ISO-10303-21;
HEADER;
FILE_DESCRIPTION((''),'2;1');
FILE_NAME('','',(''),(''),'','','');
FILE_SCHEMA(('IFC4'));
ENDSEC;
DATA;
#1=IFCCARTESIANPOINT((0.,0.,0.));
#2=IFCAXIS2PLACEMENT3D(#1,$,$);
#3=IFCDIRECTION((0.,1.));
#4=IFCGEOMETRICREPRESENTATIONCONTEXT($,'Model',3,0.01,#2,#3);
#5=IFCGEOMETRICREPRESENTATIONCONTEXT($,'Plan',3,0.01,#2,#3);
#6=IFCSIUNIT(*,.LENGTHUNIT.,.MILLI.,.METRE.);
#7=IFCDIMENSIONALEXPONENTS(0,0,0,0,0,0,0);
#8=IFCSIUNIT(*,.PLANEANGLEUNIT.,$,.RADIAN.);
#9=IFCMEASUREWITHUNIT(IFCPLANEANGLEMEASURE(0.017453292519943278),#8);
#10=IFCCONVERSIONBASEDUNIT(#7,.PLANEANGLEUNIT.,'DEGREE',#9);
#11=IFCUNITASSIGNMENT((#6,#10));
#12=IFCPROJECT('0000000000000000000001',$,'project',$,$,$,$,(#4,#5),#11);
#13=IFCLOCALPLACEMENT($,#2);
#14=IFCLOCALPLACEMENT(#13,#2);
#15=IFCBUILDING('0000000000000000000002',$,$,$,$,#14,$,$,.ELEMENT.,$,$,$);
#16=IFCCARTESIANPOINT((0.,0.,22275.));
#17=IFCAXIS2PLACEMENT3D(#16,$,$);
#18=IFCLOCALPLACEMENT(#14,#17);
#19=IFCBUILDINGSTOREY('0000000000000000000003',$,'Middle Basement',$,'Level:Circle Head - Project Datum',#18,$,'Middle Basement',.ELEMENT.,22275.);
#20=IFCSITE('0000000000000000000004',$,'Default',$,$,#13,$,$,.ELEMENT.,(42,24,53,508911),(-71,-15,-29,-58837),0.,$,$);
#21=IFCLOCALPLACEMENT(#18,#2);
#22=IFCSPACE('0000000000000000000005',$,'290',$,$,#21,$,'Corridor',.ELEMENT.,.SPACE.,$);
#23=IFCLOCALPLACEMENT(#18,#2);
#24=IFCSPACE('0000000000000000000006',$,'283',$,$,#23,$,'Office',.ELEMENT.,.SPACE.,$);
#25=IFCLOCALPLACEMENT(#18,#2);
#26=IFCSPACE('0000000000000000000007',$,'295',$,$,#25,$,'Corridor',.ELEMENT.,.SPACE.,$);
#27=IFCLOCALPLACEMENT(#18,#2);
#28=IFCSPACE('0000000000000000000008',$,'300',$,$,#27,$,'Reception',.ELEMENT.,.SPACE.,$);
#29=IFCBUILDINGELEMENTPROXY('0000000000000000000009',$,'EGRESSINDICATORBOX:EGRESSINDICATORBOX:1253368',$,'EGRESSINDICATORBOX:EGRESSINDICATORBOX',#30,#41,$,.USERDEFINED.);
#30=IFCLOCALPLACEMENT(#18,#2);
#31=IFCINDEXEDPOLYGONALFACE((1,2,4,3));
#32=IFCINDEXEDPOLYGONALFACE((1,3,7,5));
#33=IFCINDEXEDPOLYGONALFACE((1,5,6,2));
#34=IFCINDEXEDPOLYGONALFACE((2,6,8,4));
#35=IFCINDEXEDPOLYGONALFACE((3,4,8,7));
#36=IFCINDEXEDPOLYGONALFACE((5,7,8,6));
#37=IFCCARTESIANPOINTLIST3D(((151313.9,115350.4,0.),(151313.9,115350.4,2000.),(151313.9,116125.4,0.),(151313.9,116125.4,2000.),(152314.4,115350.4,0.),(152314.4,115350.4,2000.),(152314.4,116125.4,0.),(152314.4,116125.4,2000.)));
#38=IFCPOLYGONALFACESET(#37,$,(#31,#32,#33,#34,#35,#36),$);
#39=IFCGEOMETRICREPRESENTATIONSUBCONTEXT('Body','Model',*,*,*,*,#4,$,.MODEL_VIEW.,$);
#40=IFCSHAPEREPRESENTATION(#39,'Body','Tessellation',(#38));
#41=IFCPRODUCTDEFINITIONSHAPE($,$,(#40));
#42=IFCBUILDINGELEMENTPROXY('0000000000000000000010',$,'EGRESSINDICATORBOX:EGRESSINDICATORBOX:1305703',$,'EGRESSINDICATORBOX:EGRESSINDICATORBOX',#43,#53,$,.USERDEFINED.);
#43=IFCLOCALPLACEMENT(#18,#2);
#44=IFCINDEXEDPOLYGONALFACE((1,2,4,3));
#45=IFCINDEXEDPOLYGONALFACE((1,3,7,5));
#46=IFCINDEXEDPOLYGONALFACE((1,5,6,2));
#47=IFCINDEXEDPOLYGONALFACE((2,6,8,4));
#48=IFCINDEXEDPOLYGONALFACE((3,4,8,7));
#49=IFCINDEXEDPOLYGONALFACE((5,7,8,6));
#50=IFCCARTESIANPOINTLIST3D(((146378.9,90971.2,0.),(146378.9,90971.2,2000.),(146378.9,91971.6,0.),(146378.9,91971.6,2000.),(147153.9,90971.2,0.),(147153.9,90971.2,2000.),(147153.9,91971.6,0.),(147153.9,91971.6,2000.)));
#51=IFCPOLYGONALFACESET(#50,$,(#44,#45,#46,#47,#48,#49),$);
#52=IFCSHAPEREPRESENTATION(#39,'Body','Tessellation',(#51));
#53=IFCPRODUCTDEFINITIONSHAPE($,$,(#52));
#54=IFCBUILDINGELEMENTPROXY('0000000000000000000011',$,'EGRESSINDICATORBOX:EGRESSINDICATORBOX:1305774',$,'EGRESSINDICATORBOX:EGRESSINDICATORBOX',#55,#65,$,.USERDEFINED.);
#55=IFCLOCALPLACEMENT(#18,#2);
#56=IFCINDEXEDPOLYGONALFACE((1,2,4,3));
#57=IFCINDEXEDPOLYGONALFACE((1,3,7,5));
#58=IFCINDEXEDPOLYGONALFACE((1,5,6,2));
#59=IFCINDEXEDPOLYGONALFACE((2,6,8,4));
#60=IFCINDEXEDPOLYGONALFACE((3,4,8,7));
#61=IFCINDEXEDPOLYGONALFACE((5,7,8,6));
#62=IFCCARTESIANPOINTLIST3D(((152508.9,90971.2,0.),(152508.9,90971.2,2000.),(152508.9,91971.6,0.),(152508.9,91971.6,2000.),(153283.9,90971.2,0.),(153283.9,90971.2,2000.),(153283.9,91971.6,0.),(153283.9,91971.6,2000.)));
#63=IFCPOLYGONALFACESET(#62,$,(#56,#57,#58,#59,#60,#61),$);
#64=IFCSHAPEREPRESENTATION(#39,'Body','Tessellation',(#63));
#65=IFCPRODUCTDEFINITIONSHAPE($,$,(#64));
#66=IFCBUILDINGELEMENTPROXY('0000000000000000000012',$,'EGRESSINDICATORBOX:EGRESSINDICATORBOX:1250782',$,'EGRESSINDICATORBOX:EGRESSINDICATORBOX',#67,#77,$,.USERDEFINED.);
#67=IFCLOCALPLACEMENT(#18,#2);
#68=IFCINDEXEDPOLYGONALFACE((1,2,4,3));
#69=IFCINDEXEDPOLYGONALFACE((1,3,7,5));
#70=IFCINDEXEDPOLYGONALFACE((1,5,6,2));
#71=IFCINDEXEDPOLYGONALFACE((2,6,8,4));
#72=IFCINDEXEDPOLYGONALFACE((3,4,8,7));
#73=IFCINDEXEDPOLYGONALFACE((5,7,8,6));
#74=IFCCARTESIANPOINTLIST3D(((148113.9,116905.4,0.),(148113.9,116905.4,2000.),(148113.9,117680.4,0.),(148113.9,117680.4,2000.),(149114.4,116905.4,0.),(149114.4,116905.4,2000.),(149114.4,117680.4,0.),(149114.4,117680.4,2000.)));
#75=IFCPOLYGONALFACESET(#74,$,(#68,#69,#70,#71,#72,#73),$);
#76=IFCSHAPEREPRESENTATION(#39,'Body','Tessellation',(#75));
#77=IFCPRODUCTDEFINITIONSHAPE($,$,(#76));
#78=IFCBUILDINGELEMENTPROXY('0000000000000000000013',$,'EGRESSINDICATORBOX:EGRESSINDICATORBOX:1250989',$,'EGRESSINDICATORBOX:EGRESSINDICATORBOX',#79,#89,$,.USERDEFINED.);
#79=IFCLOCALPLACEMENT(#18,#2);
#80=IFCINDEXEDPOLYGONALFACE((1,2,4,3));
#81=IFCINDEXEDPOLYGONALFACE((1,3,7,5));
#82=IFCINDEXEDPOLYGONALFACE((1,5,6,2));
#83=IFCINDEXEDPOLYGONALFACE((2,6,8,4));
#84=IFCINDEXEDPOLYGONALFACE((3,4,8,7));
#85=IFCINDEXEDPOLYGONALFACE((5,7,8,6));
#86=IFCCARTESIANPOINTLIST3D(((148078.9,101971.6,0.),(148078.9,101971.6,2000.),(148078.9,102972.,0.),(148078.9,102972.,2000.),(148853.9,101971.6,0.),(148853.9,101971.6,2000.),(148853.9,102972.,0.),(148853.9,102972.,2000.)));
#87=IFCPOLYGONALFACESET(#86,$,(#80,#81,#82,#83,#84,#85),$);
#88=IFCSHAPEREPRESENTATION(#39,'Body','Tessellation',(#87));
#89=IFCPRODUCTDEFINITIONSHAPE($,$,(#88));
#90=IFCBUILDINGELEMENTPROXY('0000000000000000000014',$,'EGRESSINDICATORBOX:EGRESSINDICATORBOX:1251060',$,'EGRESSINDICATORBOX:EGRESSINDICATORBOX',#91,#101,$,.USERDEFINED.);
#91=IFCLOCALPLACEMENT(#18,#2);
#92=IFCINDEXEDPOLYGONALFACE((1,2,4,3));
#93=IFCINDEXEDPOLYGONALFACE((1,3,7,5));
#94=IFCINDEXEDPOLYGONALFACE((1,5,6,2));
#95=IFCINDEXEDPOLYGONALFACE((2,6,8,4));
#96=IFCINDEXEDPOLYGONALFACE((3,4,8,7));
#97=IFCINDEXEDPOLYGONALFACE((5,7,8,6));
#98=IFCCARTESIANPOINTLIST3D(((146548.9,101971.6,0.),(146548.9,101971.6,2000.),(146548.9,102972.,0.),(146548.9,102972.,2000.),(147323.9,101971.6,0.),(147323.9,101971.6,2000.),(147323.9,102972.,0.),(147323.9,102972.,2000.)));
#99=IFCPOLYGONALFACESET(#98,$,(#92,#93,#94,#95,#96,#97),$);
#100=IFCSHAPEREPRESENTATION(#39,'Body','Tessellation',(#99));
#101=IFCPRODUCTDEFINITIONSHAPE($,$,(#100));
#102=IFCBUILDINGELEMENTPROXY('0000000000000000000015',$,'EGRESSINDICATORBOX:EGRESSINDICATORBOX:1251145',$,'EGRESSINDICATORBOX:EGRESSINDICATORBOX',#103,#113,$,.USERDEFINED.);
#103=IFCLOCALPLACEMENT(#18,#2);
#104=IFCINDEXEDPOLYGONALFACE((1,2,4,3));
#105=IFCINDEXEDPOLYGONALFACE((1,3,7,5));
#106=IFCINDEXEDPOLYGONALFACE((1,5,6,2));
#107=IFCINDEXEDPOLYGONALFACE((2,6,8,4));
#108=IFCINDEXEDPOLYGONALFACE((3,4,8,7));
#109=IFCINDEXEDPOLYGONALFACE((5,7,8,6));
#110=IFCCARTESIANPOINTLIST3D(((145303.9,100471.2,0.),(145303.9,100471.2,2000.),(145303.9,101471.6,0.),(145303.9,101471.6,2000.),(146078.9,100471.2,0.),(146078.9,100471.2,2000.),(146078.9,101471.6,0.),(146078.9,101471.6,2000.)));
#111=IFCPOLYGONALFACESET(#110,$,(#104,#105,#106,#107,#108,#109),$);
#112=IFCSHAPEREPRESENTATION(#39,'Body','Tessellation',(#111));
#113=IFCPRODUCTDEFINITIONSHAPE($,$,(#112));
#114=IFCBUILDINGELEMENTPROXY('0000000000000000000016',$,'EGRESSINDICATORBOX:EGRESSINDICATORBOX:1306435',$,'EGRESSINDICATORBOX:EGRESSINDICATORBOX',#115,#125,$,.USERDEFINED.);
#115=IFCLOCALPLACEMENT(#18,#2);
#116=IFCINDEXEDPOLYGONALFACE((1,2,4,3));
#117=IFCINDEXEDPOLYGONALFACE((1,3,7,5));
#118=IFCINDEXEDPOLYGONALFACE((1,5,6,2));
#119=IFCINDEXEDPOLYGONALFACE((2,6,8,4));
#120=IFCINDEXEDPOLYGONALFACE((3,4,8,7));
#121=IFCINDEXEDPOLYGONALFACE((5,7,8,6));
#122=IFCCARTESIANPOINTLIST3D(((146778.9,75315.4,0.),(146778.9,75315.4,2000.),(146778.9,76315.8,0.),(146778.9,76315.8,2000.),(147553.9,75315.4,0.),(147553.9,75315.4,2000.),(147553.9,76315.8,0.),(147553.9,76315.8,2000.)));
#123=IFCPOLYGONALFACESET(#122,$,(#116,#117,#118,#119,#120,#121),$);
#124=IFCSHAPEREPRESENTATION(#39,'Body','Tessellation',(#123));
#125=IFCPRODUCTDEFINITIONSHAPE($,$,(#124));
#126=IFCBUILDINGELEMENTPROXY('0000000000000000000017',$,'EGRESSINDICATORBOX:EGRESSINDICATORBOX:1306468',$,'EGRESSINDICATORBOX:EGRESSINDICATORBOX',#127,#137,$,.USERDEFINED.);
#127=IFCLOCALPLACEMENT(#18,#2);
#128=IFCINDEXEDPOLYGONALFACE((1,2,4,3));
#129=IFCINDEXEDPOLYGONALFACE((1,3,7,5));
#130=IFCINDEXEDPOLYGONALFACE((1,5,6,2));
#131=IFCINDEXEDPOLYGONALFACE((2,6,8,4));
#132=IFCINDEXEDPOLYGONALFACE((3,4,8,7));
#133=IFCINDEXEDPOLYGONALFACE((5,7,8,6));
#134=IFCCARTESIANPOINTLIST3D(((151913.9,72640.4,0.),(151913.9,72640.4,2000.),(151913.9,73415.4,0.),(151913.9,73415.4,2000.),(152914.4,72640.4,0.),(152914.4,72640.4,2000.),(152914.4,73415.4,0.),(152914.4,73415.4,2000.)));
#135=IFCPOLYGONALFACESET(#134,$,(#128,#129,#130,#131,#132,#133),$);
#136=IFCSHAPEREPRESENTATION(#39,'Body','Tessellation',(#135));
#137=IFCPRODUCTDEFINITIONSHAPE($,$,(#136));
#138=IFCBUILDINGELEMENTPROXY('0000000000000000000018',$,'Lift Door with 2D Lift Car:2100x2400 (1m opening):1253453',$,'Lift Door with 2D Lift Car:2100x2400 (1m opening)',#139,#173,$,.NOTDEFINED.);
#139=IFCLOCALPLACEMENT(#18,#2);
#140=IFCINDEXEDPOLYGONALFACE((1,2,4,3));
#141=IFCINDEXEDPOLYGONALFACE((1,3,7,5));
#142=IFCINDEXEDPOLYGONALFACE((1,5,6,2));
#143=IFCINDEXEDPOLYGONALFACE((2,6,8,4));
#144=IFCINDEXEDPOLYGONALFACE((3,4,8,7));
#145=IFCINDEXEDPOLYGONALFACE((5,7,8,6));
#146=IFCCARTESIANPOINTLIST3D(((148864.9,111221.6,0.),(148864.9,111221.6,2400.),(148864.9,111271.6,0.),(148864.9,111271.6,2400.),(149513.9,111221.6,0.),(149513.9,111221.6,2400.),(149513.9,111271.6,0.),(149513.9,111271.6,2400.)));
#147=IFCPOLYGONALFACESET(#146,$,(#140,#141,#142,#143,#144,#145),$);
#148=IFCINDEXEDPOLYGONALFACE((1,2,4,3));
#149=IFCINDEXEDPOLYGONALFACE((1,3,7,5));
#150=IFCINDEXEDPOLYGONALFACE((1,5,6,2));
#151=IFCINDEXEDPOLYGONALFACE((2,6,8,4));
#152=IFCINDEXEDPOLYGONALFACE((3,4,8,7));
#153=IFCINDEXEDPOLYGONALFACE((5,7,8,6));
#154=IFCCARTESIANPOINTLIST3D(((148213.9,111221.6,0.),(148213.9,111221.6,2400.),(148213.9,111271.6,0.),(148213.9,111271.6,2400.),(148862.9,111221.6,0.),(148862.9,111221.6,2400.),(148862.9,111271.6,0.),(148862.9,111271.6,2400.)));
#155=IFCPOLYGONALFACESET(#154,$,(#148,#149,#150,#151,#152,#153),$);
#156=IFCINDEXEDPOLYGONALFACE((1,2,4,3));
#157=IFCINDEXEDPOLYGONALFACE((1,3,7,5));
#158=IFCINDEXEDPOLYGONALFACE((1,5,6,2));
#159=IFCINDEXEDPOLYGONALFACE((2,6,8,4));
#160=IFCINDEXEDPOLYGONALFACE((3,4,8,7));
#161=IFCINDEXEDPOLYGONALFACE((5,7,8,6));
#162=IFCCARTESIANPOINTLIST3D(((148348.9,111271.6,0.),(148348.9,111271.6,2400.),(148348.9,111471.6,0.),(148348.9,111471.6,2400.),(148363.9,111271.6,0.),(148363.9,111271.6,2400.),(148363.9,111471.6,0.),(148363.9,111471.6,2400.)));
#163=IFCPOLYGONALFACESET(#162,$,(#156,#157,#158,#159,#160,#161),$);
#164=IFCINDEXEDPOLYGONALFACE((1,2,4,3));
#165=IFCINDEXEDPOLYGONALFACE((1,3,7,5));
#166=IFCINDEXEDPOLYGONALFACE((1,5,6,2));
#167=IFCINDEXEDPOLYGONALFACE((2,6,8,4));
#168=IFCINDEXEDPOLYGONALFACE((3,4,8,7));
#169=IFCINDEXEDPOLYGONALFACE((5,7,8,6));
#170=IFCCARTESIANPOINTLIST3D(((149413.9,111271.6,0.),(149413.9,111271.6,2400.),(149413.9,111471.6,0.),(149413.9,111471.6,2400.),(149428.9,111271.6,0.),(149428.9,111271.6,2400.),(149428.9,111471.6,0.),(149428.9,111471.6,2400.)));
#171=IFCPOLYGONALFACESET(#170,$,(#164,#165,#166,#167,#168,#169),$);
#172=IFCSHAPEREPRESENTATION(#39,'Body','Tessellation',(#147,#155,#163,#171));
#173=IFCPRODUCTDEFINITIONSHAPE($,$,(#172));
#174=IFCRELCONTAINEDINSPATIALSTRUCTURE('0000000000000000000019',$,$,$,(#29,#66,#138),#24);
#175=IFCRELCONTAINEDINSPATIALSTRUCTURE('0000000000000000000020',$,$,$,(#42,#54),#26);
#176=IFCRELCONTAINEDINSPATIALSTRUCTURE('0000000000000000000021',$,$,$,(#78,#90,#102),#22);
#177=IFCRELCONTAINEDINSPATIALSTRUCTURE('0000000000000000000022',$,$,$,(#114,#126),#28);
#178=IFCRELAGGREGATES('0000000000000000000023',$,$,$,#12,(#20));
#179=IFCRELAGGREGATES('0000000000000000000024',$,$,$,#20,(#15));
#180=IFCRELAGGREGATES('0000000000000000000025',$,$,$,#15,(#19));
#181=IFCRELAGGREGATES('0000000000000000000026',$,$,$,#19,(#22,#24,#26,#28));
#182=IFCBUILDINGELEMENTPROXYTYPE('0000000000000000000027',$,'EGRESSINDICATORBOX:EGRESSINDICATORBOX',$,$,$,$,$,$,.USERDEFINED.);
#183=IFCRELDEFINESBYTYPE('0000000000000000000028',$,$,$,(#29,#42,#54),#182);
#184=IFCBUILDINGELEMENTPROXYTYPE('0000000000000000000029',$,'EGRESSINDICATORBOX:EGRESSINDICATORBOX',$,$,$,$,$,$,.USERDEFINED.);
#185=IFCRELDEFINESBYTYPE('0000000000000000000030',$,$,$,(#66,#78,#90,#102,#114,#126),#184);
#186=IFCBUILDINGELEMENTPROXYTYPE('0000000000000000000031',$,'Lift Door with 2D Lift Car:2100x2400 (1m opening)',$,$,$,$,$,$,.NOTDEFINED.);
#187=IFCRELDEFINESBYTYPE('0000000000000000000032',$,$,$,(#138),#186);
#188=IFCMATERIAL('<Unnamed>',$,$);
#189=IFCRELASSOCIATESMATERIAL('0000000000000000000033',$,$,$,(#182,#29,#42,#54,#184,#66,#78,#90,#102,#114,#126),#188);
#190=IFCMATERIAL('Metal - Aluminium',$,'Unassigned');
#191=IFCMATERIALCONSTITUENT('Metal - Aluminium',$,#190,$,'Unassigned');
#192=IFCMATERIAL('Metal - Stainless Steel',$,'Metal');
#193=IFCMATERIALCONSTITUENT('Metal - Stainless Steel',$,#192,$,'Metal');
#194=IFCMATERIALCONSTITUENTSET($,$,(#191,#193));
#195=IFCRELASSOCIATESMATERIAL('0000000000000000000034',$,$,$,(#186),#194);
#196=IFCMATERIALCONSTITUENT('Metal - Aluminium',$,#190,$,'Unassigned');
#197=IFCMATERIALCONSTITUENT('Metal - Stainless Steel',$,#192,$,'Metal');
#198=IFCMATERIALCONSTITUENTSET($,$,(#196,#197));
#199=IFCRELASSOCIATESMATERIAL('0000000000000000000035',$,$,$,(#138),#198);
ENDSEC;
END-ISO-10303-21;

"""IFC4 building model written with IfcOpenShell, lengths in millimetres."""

from ifc_helpers import new_model, entity, si_unit, converted_unit, direction, frame, origin, place, context, subcontext, project, spatial, indexed_curve, outline, extrude, source, transform, mapped, material, constituent, constituent_set, type_object, type_shapes, element, save


model = new_model("IFC4")

# Units and contexts
model_context = context("Model", 3, precision=0.01, world=origin(), true_north=direction((0.0, 1.0)))
plan_context = context("Plan", 3, precision=0.01, world=origin(), true_north=direction((0.0, 1.0)))
body_context = subcontext(model_context, "Body", "Model", "MODEL_VIEW")
ifc_project = project(units=[si_unit("LENGTHUNIT", "METRE", prefix="MILLI"), converted_unit("PLANEANGLEUNIT", "DEGREE", entity("IfcPlaneAngleMeasure", 0.017453292519943278), si_unit("PLANEANGLEUNIT", "RADIAN"), dimensions=[0, 0, 0, 0, 0, 0, 0])], contexts=[model_context, plan_context])

# Site, building, storey
site_placement = place(None, origin())
site = spatial("IfcSite", under=ifc_project, at=site_placement, Name="Default", CompositionType="ELEMENT", RefLatitude=(42, 24, 53, 508911), RefLongitude=(-71, -15, -29, -58837), RefElevation=0.0)
building_placement = place(site_placement, origin())
building = spatial("IfcBuilding", under=site, at=building_placement, CompositionType="ELEMENT")
storey_placement = place(building_placement, frame((0.0, 0.0, 22275.0)))
storey = spatial("IfcBuildingStorey", under=building, at=storey_placement, Name="Middle Basement", ObjectType="Level:Circle Head - Project Datum", LongName="Middle Basement", CompositionType="ELEMENT", Elevation=22275.0)

# Shared definitions
ifc_material_1 = material(Name="<Unnamed>")

# Shared definitions
building_element_proxy_type_1 = type_object("IfcBuildingElementProxyType", Name="EGRESSINDICATORBOX:EGRESSINDICATORBOX", PredefinedType="USERDEFINED", material=ifc_material_1)
shared_shape_1 = source(origin(), body_context, "Body", "SweptSolid", [
    extrude(outline(indexed_curve([(-387.5, -500.2), (387.5, -500.2), (387.5, 500.2), (-387.5, 500.2), (-387.5, -500.2)], self_intersect=False)), frame((0.0, 0.0, 0.0), z_axis=(0.0, 0.0, 1.0), x_axis=(-1.0, 0.0, 0.0)), (0.0, 0.0, 1.0), 2000.0),
])
type_shapes(building_element_proxy_type_1, [shared_shape_1])

# Shared definitions
space_1_placement = place(storey_placement, origin())
space_1 = spatial("IfcSpace", under=storey, at=space_1_placement, Name="290", LongName="Corridor", CompositionType="ELEMENT", PredefinedType="SPACE")

# Shared definitions
space_2_placement = place(storey_placement, origin())
space_2 = spatial("IfcSpace", under=storey, at=space_2_placement, Name="283", LongName="Office", CompositionType="ELEMENT", PredefinedType="SPACE")

# Building element proxy
proxy_1_placement = place(space_2_placement, frame((151814.2, 115737.9, 0.0), z_axis=(0.0, 0.0, 1.0), x_axis=(0.0, 1.0, 0.0)))
element("IfcBuildingElementProxy", 1, at=proxy_1_placement, inside=space_2, type_object=building_element_proxy_type_1, material=ifc_material_1, Name="EGRESSINDICATORBOX:EGRESSINDICATORBOX:1253368", ObjectType="EGRESSINDICATORBOX:EGRESSINDICATORBOX", PredefinedType="USERDEFINED", context=body_context, shape_type="MappedRepresentation", body=[
    mapped(shared_shape_1, transform((0.0, 0.0, 0.0), scale=1.0)),
])

# Shared definitions
space_3_placement = place(storey_placement, origin())
space_3 = spatial("IfcSpace", under=storey, at=space_3_placement, Name="295", LongName="Corridor", CompositionType="ELEMENT", PredefinedType="SPACE")

# Building element proxies
for number, where, name in (
    (2, (146766.4, 91471.4, 0.0), "EGRESSINDICATORBOX:EGRESSINDICATORBOX:1305703"),
    (3, (152896.4, 91471.4, 0.0), "EGRESSINDICATORBOX:EGRESSINDICATORBOX:1305774"),
):
    element("IfcBuildingElementProxy", number, at=place(space_3_placement, frame(where)), inside=space_3, type_object=building_element_proxy_type_1, material=ifc_material_1, Name=name, ObjectType="EGRESSINDICATORBOX:EGRESSINDICATORBOX", PredefinedType="USERDEFINED", context=body_context, shape_type="MappedRepresentation", body=[
        mapped(shared_shape_1, transform((0.0, 0.0, 0.0), scale=1.0)),
    ])
building_element_proxy_type_2 = type_object("IfcBuildingElementProxyType", Name="EGRESSINDICATORBOX:EGRESSINDICATORBOX", PredefinedType="USERDEFINED", material=ifc_material_1)
shared_shape_2 = source(origin(), body_context, "Body", "SweptSolid", [
    extrude(outline(indexed_curve([(-500.2, -387.5), (500.2, -387.5), (500.2, 387.5), (-500.2, 387.5), (-500.2, -387.5)], self_intersect=False)), frame((0.0, 0.0, 0.0), z_axis=(0.0, 0.0, 1.0), x_axis=(0.0, 1.0, 0.0)), (0.0, 0.0, 1.0), 2000.0),
])
type_shapes(building_element_proxy_type_2, [shared_shape_2])
proxy_2_placement = place(space_2_placement, frame((148614.2, 117292.9, 0.0), z_axis=(0.0, 0.0, 1.0), x_axis=(0.0, -1.0, 0.0)))
element("IfcBuildingElementProxy", 4, at=proxy_2_placement, inside=space_2, type_object=building_element_proxy_type_2, material=ifc_material_1, Name="EGRESSINDICATORBOX:EGRESSINDICATORBOX:1250782", ObjectType="EGRESSINDICATORBOX:EGRESSINDICATORBOX", PredefinedType="USERDEFINED", context=body_context, shape_type="MappedRepresentation", body=[
    mapped(shared_shape_2, transform((0.0, 0.0, 0.0), scale=1.0)),
])
for number, where, name in (
    (5, (148466.4, 102471.8, 0.0), "EGRESSINDICATORBOX:EGRESSINDICATORBOX:1250989"),
    (6, (146936.4, 102471.8, 0.0), "EGRESSINDICATORBOX:EGRESSINDICATORBOX:1251060"),
):
    element("IfcBuildingElementProxy", number, at=place(space_1_placement, frame(where)), inside=space_1, type_object=building_element_proxy_type_2, material=ifc_material_1, Name=name, ObjectType="EGRESSINDICATORBOX:EGRESSINDICATORBOX", PredefinedType="USERDEFINED", context=body_context, shape_type="MappedRepresentation", body=[
        mapped(shared_shape_2, transform((0.0, 0.0, 0.0), scale=1.0)),
    ])
proxy_3_placement = place(space_1_placement, frame((145691.4, 100971.4, 0.0), z_axis=(0.0, 0.0, 1.0), x_axis=(-1.0, 0.0, 0.0)))
element("IfcBuildingElementProxy", 7, at=proxy_3_placement, inside=space_1, type_object=building_element_proxy_type_2, material=ifc_material_1, Name="EGRESSINDICATORBOX:EGRESSINDICATORBOX:1251145", ObjectType="EGRESSINDICATORBOX:EGRESSINDICATORBOX", PredefinedType="USERDEFINED", context=body_context, shape_type="MappedRepresentation", body=[
    mapped(shared_shape_2, transform((0.0, 0.0, 0.0), scale=1.0)),
])

# Shared definitions
space_4_placement = place(storey_placement, origin())
space_4 = spatial("IfcSpace", under=storey, at=space_4_placement, Name="300", LongName="Reception", CompositionType="ELEMENT", PredefinedType="SPACE")

# Building element proxies
proxy_4_placement = place(space_4_placement, frame((147166.4, 75815.6, 0.0)))
element("IfcBuildingElementProxy", 8, at=proxy_4_placement, inside=space_4, type_object=building_element_proxy_type_2, material=ifc_material_1, Name="EGRESSINDICATORBOX:EGRESSINDICATORBOX:1306435", ObjectType="EGRESSINDICATORBOX:EGRESSINDICATORBOX", PredefinedType="USERDEFINED", context=body_context, shape_type="MappedRepresentation", body=[
    mapped(shared_shape_2, transform((0.0, 0.0, 0.0), scale=1.0)),
])
proxy_5_placement = place(space_4_placement, frame((152414.2, 73027.9, 0.0), z_axis=(0.0, 0.0, 1.0), x_axis=(0.0, -1.0, 0.0)))
element("IfcBuildingElementProxy", 9, at=proxy_5_placement, inside=space_4, type_object=building_element_proxy_type_2, material=ifc_material_1, Name="EGRESSINDICATORBOX:EGRESSINDICATORBOX:1306468", ObjectType="EGRESSINDICATORBOX:EGRESSINDICATORBOX", PredefinedType="USERDEFINED", context=body_context, shape_type="MappedRepresentation", body=[
    mapped(shared_shape_2, transform((0.0, 0.0, 0.0), scale=1.0)),
])
ifc_material_2 = material(Name="Metal - Aluminium", Category="Unassigned")
ifc_constituent_1 = constituent(ifc_material_2, Name="Metal - Aluminium", Category="Unassigned")
ifc_material_3 = material(Name="Metal - Stainless Steel", Category="Metal")
ifc_constituent_2 = constituent(ifc_material_3, Name="Metal - Stainless Steel", Category="Metal")
ifc_constituent_set_1 = constituent_set(constituents=[ifc_constituent_1, ifc_constituent_2])
ifc_constituent_3 = constituent(ifc_material_2, Name="Metal - Aluminium", Category="Unassigned")
ifc_constituent_4 = constituent(ifc_material_3, Name="Metal - Stainless Steel", Category="Metal")
ifc_constituent_set_2 = constituent_set(constituents=[ifc_constituent_3, ifc_constituent_4])
building_element_proxy_type_3 = type_object("IfcBuildingElementProxyType", Name="Lift Door with 2D Lift Car:2100x2400 (1m opening)", PredefinedType="NOTDEFINED", material=ifc_constituent_set_2)
shared_shape_3 = source(origin(), body_context, "Body", "SweptSolid", [
    extrude(outline(indexed_curve([(-324.5, -25.0), (324.5, -25.0), (324.5, 25.0), (-324.5, 25.0), (-324.5, -25.0)], self_intersect=False)), frame((-575.5, 125.0, 0.0), z_axis=(0.0, 0.0, 1.0), x_axis=(-1.0, 0.0, 0.0)), (0.0, 0.0, 1.0), 2400.0),
    extrude(outline(indexed_curve([(-324.5, -25.0), (324.5, -25.0), (324.5, 25.0), (-324.5, 25.0), (-324.5, -25.0)], self_intersect=False)), frame((75.5, 125.0, 0.0), z_axis=(0.0, 0.0, 1.0), x_axis=(-1.0, 0.0, 0.0)), (0.0, 0.0, 1.0), 2400.0),
    extrude(outline(indexed_curve([(-7.5, -100.0), (7.5, -100.0), (7.5, 100.0), (-7.5, 100.0), (-7.5, -100.0)], self_intersect=False)), frame((257.5, 0.0, 0.0), z_axis=(0.0, 0.0, 1.0), x_axis=(-1.0, 0.0, 0.0)), (0.0, 0.0, 1.0), 2400.0),
    extrude(outline(indexed_curve([(-100.0, -7.5), (100.0, -7.5), (100.0, 7.5), (-100.0, 7.5), (-100.0, -7.5)], self_intersect=False)), frame((-807.5, 0.0, 0.0), z_axis=(0.0, 0.0, 1.0), x_axis=(0.0, -1.0, 0.0)), (0.0, 0.0, 1.0), 2400.0),
])
type_shapes(building_element_proxy_type_3, [shared_shape_3])
proxy_6_placement = place(space_2_placement, frame((148613.9, 111371.6, 0.0), z_axis=(0.0, 0.0, 1.0), x_axis=(-1.0, 0.0, 0.0)))
element("IfcBuildingElementProxy", 10, at=proxy_6_placement, inside=space_2, type_object=building_element_proxy_type_3, material=ifc_constituent_set_1, Name="Lift Door with 2D Lift Car:2100x2400 (1m opening):1253453", ObjectType="Lift Door with 2D Lift Car:2100x2400 (1m opening)", PredefinedType="NOTDEFINED", context=body_context, shape_type="MappedRepresentation", body=[
    mapped(shared_shape_3, transform((0.0, 0.0, 0.0), scale=1.0)),
])

save(model, "model.ifc")
